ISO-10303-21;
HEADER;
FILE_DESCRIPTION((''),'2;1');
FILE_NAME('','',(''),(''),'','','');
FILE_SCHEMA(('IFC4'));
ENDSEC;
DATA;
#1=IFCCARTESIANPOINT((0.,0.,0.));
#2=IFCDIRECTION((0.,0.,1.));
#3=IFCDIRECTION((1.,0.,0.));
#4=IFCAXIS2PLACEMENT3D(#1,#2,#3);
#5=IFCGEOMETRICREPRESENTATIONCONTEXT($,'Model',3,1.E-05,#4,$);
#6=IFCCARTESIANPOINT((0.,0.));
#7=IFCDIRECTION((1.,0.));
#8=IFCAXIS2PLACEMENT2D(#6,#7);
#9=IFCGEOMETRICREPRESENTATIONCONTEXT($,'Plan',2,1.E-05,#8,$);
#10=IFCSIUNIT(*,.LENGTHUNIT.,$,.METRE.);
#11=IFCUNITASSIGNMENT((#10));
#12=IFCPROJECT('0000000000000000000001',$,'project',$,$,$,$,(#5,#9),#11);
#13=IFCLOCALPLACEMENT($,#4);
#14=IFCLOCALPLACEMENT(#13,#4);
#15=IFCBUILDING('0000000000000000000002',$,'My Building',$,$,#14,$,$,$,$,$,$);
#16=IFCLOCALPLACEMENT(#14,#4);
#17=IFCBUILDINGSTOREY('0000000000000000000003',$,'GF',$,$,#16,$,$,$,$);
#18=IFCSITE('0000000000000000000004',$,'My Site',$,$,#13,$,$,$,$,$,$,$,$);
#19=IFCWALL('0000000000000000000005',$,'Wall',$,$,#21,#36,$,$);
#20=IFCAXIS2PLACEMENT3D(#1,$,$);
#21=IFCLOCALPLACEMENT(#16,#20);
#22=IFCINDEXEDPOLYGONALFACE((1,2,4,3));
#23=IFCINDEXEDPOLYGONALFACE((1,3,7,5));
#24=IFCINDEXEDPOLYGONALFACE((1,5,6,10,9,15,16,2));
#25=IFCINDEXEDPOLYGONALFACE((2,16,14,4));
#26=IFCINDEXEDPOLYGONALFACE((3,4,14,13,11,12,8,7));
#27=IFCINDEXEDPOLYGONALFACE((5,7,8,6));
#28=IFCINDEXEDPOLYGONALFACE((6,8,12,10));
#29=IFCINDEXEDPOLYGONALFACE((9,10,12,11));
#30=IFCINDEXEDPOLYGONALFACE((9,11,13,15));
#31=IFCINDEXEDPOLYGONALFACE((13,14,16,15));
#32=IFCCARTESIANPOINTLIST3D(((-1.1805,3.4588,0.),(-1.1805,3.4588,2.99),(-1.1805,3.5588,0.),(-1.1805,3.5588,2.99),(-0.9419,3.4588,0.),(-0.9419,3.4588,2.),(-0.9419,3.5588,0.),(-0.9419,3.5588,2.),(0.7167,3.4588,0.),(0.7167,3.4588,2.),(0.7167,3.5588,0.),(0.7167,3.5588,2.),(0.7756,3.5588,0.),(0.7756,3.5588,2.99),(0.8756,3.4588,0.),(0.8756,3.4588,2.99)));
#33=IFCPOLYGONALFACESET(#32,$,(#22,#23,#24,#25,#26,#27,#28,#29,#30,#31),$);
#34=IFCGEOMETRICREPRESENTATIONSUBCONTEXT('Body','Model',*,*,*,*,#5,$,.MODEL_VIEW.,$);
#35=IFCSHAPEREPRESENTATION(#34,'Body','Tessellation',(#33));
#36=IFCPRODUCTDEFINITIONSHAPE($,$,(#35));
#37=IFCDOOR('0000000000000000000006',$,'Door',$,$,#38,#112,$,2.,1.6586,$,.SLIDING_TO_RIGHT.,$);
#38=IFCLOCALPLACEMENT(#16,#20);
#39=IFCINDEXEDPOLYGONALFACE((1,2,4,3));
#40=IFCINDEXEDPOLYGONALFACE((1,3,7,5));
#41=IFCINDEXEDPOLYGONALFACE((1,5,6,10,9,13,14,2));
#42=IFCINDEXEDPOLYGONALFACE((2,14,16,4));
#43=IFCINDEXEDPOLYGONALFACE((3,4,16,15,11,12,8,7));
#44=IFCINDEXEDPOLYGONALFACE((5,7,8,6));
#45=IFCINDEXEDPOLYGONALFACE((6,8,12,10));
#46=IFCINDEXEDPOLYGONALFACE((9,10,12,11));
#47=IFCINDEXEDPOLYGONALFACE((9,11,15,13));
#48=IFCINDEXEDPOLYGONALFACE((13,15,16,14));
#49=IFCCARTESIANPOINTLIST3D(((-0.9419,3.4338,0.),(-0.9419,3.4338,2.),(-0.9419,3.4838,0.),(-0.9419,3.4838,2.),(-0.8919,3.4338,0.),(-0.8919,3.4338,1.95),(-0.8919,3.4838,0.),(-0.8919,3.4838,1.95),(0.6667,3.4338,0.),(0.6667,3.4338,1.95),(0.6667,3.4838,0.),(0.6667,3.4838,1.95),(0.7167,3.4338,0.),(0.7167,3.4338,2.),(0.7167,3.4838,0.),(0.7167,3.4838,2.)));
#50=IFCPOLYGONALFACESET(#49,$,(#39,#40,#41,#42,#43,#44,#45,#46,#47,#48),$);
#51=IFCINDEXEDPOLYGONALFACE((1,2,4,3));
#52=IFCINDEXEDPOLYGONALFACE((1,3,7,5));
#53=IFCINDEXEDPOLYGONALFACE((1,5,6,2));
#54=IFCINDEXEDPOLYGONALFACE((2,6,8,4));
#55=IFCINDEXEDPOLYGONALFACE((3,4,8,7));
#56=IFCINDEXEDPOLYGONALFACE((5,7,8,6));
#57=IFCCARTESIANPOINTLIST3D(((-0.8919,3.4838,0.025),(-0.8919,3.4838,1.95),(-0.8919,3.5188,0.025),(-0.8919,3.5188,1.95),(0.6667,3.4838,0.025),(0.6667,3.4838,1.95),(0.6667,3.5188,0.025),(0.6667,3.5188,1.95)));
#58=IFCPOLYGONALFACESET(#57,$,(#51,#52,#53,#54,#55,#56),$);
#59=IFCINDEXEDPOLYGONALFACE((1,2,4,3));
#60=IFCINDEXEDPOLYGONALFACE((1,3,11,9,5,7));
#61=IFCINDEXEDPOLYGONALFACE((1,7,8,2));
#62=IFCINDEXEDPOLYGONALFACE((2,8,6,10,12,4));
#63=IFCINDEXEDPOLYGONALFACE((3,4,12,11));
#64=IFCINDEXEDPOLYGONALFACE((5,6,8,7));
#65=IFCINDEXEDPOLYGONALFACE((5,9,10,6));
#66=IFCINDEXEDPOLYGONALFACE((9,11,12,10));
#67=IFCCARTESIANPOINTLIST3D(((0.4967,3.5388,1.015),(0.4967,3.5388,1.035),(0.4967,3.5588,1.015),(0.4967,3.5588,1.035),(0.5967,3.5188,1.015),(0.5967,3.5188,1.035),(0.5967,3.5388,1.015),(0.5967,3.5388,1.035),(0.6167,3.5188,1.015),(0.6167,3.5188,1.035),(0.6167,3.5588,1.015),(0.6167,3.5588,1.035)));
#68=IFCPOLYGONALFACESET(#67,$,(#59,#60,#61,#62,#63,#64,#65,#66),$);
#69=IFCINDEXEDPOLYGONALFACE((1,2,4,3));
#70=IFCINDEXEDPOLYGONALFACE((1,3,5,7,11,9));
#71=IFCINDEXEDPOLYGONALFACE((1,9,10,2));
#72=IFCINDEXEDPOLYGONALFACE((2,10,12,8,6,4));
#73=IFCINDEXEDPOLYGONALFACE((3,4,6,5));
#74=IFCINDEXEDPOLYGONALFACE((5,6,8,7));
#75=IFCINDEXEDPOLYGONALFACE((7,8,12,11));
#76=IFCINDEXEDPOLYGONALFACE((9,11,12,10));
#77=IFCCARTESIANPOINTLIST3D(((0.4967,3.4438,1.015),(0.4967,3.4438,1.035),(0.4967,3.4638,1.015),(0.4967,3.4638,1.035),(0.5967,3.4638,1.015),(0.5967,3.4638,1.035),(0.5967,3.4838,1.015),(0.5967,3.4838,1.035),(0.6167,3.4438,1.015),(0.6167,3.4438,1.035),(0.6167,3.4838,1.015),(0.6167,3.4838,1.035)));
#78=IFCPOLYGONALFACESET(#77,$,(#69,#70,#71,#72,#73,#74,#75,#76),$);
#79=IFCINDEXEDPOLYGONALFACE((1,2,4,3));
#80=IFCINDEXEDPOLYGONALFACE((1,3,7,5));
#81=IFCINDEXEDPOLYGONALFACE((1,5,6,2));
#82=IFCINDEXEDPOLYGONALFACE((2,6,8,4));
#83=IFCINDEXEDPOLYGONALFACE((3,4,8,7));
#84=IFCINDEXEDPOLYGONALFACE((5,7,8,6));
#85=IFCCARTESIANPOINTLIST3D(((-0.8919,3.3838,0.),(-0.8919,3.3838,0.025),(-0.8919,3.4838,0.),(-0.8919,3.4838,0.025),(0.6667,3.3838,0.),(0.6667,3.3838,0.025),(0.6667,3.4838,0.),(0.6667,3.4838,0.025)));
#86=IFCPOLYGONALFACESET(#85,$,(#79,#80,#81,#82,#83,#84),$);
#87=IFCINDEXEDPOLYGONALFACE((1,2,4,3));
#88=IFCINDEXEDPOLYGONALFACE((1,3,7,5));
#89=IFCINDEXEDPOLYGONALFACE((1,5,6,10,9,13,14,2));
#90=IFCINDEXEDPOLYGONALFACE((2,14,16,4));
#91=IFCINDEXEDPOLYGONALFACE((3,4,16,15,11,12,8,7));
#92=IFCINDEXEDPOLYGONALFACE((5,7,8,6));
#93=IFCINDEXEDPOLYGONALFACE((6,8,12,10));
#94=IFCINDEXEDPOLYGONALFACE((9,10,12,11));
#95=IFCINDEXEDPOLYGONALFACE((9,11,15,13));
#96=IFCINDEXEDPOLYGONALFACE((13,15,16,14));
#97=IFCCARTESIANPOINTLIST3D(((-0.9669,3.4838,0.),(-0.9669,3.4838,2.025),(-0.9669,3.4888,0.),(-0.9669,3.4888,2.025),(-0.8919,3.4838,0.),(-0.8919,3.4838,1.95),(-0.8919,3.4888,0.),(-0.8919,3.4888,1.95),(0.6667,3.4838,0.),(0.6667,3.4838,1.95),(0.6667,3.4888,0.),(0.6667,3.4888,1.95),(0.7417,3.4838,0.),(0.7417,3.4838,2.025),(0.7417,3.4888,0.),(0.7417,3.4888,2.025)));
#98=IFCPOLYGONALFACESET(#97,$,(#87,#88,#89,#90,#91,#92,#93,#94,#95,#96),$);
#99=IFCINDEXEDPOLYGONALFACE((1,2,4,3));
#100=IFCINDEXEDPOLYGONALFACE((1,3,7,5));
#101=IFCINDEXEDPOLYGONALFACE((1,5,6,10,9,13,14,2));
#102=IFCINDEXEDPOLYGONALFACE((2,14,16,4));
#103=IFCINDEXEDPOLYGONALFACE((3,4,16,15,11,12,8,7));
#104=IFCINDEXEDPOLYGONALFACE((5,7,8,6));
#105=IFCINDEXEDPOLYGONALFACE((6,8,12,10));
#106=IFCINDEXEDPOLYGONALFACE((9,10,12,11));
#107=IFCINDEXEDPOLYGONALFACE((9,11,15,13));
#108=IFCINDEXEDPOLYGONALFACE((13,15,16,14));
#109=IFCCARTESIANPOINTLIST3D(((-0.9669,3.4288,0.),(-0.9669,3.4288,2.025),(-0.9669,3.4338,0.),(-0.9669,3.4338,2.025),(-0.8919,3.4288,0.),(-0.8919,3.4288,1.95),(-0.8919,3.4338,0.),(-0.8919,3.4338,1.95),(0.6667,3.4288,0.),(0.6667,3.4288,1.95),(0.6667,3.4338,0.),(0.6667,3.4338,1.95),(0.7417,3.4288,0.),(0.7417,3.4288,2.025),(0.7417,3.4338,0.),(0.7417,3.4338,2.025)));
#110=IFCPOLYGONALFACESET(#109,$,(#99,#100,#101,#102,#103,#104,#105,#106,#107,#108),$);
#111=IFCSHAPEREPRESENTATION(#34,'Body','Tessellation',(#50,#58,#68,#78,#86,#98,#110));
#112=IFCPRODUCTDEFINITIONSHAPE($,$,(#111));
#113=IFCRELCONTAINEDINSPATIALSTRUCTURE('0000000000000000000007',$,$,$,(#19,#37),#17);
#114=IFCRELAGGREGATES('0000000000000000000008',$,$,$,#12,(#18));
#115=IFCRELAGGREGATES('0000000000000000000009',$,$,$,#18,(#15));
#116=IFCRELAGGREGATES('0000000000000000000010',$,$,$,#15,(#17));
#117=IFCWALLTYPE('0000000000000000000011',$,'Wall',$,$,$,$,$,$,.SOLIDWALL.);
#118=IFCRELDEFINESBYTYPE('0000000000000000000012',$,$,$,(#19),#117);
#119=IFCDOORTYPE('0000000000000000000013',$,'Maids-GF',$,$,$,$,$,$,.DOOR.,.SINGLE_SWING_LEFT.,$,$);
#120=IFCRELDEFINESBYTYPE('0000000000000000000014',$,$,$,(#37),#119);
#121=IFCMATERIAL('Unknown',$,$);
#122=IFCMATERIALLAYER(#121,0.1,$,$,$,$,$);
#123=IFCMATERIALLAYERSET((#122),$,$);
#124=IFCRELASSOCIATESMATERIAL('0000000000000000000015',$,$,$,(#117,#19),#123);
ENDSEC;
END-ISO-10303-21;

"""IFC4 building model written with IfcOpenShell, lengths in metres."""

from ifc_helpers import new_model, entity, si_unit, frame, origin_with_axes, origin_2d_with_axis, place, context, subcontext, project, spatial, line, indexed_curve, outline, extrude, shape, source, transform, mapped, material, layer, layer_set, layer_usage, type_object, type_shapes, element, fill, save


model = new_model("IFC4")

# Units and contexts
model_context = context("Model", 3, precision=1e-05, world=origin_with_axes())
plan_context = context("Plan", 2, precision=1e-05, world=origin_2d_with_axis())
body_context_1 = subcontext(model_context, "Body", "Model", "MODEL_VIEW")
body_context_2 = subcontext(plan_context, "Body", "Plan", "PLAN_VIEW")
ifc_project = project(units=[si_unit("LENGTHUNIT", "METRE")], contexts=[model_context, plan_context])

# Site, building, storey
site_placement = place(None, origin_with_axes())
site = spatial("IfcSite", under=ifc_project, at=site_placement, Name="My Site")
building_placement = place(site_placement, origin_with_axes())
building = spatial("IfcBuilding", under=site, at=building_placement, Name="My Building")
storey_placement = place(building_placement, origin_with_axes())
storey = spatial("IfcBuildingStorey", under=building, at=storey_placement, Name="GF")

# Shared definitions
ifc_material_1 = material(Name="Unknown")

# Shared definitions
ifc_layer_1 = layer(ifc_material_1, 0.1)
ifc_layer_set_1 = layer_set([ifc_layer_1])
wall_type = type_object("IfcWallType", Name="Wall", PredefinedType="SOLIDWALL", material=ifc_layer_set_1)

# Wall, opening, door
ifc_layer_usage_1 = layer_usage(ifc_layer_set_1, "AXIS2", "POSITIVE", 0.0)
wall_1_placement = place(storey_placement, frame((0.7756, 3.5588, 0.0), z_axis=(0.0, 0.0, 1.0), x_axis=(-1.0, 0.0, 0.0)))
wall_1 = element("IfcWall", 1, at=wall_1_placement, inside=storey, type_object=wall_type, material=ifc_layer_usage_1, Name="Wall", context=body_context_1, shape_type="SweptSolid", body=[
    extrude(outline(indexed_curve([(0.0, 0.0), (-0.1, 0.1), (1.9562, 0.1), (1.9562, 0.0)], segments=[line(1, 2, 3, 4, 1)])), origin_with_axes(), (0.0, 0.0, 1.0), 2.99),
])
shared_shape_1 = source(origin_with_axes(), body_context_1, "Body", "SweptSolid", [
    extrude(outline(indexed_curve([(0.0, 0.0), (1.6586, 0.0), (1.6586, 2.0), (0.0, 2.0)], segments=[line(1, 2, 3, 4, 1)])), frame((0.0, -0.6, 0.0), z_axis=(0.0, -1.0, 0.0), x_axis=(1.0, 0.0, 0.0)), (0.0, 0.0, -1.0), 1.2),
])
opening_1_placement = place(wall_1_placement, frame((0.0589, 0.075, 0.0), z_axis=(0.0, 0.0, 1.0), x_axis=(1.0, 0.0, 0.0)))
opening_1 = element("IfcOpeningElement", 2, at=opening_1_placement, cuts=wall_1, PredefinedType="OPENING", context=body_context_1, shape_type="MappedRepresentation", body=[
    mapped(shared_shape_1, transform((0.0, 0.0, 0.0), x_axis=(1.0, 0.0, 0.0), y_axis=(0.0, 1.0, 0.0), z_axis=(0.0, 0.0, 1.0), scale=1.0)),
])
door_type_1 = type_object("IfcDoorType", Name="Maids-GF", OperationType="SINGLE_SWING_LEFT", PredefinedType="DOOR")
shared_shape_2 = source(origin_with_axes(), body_context_1, "Body", "SweptSolid", [
    extrude(outline(indexed_curve([(0.0, 0.0), (0.0, 2.0), (1.6586, 2.0), (1.6586, 0.0), (1.6086, 0.0), (1.6086, 1.95), (0.05, 1.95), (0.05, 0.0)], segments=[line(1, 2, 3, 4, 5, 6, 7, 8, 1)])), frame((0.0, 0.0, 0.0), z_axis=(0.0, -1.0, 0.0), x_axis=(1.0, 0.0, 0.0)), (0.0, 0.0, -1.0), 0.05),
    extrude(outline(indexed_curve([(0.0, 0.0), (1.5586, 0.0), (1.5586, 0.035), (0.0, 0.035)], segments=[line(1, 2, 3, 4, 1)])), frame((0.05, -0.035, 0.025), z_axis=(0.0, 0.0, 1.0), x_axis=(1.0, 0.0, 0.0)), (0.0, 0.0, 1.0), 1.925),
    extrude(outline(indexed_curve([(0.0, 0.0), (0.0, -0.04), (0.12, -0.04), (0.12, -0.02), (0.02, -0.02), (0.02, 0.0)], segments=[line(1, 2, 3, 4, 5, 6, 1)])), frame((0.1, -0.035, 1.015), z_axis=(0.0, 0.0, 1.0), x_axis=(1.0, 0.0, 0.0)), (0.0, 0.0, 1.0), 0.02),
    extrude(outline(indexed_curve([(0.0, 0.0), (0.0, 0.04), (0.12, 0.04), (0.12, 0.02), (0.02, 0.02), (0.02, 0.0)], segments=[line(1, 2, 3, 4, 5, 6, 1)])), frame((0.1, 0.0, 1.015), z_axis=(0.0, 0.0, 1.0), x_axis=(1.0, 0.0, 0.0)), (0.0, 0.0, 1.0), 0.02),
    extrude(outline(indexed_curve([(0.0, 0.0), (1.5586, 0.0), (1.5586, 0.1), (0.0, 0.1)], segments=[line(1, 2, 3, 4, 1)])), frame((0.05, 0.0, 0.0), z_axis=(0.0, 0.0, 1.0), x_axis=(1.0, 0.0, 0.0)), (0.0, 0.0, 1.0), 0.025),
    extrude(outline(indexed_curve([(0.0, 0.0), (0.0, 2.025), (1.7086, 2.025), (1.7086, 0.0), (1.6336, 0.0), (1.6336, 1.95), (0.075, 1.95), (0.075, 0.0)], segments=[line(1, 2, 3, 4, 5, 6, 7, 8, 1)])), frame((-0.025, -0.005, 0.0), z_axis=(0.0, -1.0, 0.0), x_axis=(1.0, 0.0, 0.0)), (0.0, 0.0, -1.0), 0.005),
    extrude(outline(indexed_curve([(0.0, 0.0), (0.0, 2.025), (1.7086, 2.025), (1.7086, 0.0), (1.6336, 0.0), (1.6336, 1.95), (0.075, 1.95), (0.075, 0.0)], segments=[line(1, 2, 3, 4, 5, 6, 7, 8, 1)])), frame((-0.025, 0.05, 0.0), z_axis=(0.0, -1.0, 0.0), x_axis=(1.0, 0.0, 0.0)), (0.0, 0.0, -1.0), 0.005),
])
shared_shape_3 = source(origin_with_axes(), body_context_2, "Body", "Curve2D", [
    entity("IfcIndexedPolyCurve", entity("IfcCartesianPointList2D", [[0.0, 0.0], [0.05, 0.0], [0.05, 0.05], [0.0, 0.05]]), [entity("IfcLineIndex", [1, 2, 3, 4, 1])]),
    entity("IfcIndexedPolyCurve", entity("IfcCartesianPointList2D", [[1.6586, 0.0], [1.6086, 0.0], [1.6086, 0.05], [1.6586, 0.05]]), [entity("IfcLineIndex", [1, 2, 3, 4, 1])]),
    entity("IfcIndexedPolyCurve", entity("IfcCartesianPointList2D", [[2.3879, -0.035], [0.8293, -0.035], [0.8293, 0.0], [2.3879, 0.0]]), [entity("IfcLineIndex", [1, 2, 3, 4, 1])]),
])
type_shapes(door_type_1, [shared_shape_2, shared_shape_3])
door_1_placement = place(opening_1_placement, frame((0.0, 0.0, 0.0), z_axis=(0.0, 0.0, 1.0), x_axis=(1.0, 0.0, 0.0)))
door_1 = element("IfcDoor", 3, at=door_1_placement, inside=storey, type_object=door_type_1, Name="Door", OperationType="SLIDING_TO_RIGHT", OverallHeight=2.0, OverallWidth=1.6586, shapes=[
    shape(body_context_1, "Body", "MappedRepresentation", [mapped(shared_shape_2, transform((0.0, 0.0, 0.0), x_axis=(1.0, 0.0, 0.0), y_axis=(0.0, 1.0, 0.0), z_axis=(0.0, 0.0, 1.0), scale=1.0))]),
    shape(body_context_2, "Body", "MappedRepresentation", [mapped(shared_shape_3, transform((0.0, 0.0, 0.0), x_axis=(1.0, 0.0, 0.0), y_axis=(0.0, 1.0, 0.0), z_axis=(0.0, 0.0, 1.0), scale=1.0))]),
])
fill(opening_1, door_1)

save(model, "model.ifc")
